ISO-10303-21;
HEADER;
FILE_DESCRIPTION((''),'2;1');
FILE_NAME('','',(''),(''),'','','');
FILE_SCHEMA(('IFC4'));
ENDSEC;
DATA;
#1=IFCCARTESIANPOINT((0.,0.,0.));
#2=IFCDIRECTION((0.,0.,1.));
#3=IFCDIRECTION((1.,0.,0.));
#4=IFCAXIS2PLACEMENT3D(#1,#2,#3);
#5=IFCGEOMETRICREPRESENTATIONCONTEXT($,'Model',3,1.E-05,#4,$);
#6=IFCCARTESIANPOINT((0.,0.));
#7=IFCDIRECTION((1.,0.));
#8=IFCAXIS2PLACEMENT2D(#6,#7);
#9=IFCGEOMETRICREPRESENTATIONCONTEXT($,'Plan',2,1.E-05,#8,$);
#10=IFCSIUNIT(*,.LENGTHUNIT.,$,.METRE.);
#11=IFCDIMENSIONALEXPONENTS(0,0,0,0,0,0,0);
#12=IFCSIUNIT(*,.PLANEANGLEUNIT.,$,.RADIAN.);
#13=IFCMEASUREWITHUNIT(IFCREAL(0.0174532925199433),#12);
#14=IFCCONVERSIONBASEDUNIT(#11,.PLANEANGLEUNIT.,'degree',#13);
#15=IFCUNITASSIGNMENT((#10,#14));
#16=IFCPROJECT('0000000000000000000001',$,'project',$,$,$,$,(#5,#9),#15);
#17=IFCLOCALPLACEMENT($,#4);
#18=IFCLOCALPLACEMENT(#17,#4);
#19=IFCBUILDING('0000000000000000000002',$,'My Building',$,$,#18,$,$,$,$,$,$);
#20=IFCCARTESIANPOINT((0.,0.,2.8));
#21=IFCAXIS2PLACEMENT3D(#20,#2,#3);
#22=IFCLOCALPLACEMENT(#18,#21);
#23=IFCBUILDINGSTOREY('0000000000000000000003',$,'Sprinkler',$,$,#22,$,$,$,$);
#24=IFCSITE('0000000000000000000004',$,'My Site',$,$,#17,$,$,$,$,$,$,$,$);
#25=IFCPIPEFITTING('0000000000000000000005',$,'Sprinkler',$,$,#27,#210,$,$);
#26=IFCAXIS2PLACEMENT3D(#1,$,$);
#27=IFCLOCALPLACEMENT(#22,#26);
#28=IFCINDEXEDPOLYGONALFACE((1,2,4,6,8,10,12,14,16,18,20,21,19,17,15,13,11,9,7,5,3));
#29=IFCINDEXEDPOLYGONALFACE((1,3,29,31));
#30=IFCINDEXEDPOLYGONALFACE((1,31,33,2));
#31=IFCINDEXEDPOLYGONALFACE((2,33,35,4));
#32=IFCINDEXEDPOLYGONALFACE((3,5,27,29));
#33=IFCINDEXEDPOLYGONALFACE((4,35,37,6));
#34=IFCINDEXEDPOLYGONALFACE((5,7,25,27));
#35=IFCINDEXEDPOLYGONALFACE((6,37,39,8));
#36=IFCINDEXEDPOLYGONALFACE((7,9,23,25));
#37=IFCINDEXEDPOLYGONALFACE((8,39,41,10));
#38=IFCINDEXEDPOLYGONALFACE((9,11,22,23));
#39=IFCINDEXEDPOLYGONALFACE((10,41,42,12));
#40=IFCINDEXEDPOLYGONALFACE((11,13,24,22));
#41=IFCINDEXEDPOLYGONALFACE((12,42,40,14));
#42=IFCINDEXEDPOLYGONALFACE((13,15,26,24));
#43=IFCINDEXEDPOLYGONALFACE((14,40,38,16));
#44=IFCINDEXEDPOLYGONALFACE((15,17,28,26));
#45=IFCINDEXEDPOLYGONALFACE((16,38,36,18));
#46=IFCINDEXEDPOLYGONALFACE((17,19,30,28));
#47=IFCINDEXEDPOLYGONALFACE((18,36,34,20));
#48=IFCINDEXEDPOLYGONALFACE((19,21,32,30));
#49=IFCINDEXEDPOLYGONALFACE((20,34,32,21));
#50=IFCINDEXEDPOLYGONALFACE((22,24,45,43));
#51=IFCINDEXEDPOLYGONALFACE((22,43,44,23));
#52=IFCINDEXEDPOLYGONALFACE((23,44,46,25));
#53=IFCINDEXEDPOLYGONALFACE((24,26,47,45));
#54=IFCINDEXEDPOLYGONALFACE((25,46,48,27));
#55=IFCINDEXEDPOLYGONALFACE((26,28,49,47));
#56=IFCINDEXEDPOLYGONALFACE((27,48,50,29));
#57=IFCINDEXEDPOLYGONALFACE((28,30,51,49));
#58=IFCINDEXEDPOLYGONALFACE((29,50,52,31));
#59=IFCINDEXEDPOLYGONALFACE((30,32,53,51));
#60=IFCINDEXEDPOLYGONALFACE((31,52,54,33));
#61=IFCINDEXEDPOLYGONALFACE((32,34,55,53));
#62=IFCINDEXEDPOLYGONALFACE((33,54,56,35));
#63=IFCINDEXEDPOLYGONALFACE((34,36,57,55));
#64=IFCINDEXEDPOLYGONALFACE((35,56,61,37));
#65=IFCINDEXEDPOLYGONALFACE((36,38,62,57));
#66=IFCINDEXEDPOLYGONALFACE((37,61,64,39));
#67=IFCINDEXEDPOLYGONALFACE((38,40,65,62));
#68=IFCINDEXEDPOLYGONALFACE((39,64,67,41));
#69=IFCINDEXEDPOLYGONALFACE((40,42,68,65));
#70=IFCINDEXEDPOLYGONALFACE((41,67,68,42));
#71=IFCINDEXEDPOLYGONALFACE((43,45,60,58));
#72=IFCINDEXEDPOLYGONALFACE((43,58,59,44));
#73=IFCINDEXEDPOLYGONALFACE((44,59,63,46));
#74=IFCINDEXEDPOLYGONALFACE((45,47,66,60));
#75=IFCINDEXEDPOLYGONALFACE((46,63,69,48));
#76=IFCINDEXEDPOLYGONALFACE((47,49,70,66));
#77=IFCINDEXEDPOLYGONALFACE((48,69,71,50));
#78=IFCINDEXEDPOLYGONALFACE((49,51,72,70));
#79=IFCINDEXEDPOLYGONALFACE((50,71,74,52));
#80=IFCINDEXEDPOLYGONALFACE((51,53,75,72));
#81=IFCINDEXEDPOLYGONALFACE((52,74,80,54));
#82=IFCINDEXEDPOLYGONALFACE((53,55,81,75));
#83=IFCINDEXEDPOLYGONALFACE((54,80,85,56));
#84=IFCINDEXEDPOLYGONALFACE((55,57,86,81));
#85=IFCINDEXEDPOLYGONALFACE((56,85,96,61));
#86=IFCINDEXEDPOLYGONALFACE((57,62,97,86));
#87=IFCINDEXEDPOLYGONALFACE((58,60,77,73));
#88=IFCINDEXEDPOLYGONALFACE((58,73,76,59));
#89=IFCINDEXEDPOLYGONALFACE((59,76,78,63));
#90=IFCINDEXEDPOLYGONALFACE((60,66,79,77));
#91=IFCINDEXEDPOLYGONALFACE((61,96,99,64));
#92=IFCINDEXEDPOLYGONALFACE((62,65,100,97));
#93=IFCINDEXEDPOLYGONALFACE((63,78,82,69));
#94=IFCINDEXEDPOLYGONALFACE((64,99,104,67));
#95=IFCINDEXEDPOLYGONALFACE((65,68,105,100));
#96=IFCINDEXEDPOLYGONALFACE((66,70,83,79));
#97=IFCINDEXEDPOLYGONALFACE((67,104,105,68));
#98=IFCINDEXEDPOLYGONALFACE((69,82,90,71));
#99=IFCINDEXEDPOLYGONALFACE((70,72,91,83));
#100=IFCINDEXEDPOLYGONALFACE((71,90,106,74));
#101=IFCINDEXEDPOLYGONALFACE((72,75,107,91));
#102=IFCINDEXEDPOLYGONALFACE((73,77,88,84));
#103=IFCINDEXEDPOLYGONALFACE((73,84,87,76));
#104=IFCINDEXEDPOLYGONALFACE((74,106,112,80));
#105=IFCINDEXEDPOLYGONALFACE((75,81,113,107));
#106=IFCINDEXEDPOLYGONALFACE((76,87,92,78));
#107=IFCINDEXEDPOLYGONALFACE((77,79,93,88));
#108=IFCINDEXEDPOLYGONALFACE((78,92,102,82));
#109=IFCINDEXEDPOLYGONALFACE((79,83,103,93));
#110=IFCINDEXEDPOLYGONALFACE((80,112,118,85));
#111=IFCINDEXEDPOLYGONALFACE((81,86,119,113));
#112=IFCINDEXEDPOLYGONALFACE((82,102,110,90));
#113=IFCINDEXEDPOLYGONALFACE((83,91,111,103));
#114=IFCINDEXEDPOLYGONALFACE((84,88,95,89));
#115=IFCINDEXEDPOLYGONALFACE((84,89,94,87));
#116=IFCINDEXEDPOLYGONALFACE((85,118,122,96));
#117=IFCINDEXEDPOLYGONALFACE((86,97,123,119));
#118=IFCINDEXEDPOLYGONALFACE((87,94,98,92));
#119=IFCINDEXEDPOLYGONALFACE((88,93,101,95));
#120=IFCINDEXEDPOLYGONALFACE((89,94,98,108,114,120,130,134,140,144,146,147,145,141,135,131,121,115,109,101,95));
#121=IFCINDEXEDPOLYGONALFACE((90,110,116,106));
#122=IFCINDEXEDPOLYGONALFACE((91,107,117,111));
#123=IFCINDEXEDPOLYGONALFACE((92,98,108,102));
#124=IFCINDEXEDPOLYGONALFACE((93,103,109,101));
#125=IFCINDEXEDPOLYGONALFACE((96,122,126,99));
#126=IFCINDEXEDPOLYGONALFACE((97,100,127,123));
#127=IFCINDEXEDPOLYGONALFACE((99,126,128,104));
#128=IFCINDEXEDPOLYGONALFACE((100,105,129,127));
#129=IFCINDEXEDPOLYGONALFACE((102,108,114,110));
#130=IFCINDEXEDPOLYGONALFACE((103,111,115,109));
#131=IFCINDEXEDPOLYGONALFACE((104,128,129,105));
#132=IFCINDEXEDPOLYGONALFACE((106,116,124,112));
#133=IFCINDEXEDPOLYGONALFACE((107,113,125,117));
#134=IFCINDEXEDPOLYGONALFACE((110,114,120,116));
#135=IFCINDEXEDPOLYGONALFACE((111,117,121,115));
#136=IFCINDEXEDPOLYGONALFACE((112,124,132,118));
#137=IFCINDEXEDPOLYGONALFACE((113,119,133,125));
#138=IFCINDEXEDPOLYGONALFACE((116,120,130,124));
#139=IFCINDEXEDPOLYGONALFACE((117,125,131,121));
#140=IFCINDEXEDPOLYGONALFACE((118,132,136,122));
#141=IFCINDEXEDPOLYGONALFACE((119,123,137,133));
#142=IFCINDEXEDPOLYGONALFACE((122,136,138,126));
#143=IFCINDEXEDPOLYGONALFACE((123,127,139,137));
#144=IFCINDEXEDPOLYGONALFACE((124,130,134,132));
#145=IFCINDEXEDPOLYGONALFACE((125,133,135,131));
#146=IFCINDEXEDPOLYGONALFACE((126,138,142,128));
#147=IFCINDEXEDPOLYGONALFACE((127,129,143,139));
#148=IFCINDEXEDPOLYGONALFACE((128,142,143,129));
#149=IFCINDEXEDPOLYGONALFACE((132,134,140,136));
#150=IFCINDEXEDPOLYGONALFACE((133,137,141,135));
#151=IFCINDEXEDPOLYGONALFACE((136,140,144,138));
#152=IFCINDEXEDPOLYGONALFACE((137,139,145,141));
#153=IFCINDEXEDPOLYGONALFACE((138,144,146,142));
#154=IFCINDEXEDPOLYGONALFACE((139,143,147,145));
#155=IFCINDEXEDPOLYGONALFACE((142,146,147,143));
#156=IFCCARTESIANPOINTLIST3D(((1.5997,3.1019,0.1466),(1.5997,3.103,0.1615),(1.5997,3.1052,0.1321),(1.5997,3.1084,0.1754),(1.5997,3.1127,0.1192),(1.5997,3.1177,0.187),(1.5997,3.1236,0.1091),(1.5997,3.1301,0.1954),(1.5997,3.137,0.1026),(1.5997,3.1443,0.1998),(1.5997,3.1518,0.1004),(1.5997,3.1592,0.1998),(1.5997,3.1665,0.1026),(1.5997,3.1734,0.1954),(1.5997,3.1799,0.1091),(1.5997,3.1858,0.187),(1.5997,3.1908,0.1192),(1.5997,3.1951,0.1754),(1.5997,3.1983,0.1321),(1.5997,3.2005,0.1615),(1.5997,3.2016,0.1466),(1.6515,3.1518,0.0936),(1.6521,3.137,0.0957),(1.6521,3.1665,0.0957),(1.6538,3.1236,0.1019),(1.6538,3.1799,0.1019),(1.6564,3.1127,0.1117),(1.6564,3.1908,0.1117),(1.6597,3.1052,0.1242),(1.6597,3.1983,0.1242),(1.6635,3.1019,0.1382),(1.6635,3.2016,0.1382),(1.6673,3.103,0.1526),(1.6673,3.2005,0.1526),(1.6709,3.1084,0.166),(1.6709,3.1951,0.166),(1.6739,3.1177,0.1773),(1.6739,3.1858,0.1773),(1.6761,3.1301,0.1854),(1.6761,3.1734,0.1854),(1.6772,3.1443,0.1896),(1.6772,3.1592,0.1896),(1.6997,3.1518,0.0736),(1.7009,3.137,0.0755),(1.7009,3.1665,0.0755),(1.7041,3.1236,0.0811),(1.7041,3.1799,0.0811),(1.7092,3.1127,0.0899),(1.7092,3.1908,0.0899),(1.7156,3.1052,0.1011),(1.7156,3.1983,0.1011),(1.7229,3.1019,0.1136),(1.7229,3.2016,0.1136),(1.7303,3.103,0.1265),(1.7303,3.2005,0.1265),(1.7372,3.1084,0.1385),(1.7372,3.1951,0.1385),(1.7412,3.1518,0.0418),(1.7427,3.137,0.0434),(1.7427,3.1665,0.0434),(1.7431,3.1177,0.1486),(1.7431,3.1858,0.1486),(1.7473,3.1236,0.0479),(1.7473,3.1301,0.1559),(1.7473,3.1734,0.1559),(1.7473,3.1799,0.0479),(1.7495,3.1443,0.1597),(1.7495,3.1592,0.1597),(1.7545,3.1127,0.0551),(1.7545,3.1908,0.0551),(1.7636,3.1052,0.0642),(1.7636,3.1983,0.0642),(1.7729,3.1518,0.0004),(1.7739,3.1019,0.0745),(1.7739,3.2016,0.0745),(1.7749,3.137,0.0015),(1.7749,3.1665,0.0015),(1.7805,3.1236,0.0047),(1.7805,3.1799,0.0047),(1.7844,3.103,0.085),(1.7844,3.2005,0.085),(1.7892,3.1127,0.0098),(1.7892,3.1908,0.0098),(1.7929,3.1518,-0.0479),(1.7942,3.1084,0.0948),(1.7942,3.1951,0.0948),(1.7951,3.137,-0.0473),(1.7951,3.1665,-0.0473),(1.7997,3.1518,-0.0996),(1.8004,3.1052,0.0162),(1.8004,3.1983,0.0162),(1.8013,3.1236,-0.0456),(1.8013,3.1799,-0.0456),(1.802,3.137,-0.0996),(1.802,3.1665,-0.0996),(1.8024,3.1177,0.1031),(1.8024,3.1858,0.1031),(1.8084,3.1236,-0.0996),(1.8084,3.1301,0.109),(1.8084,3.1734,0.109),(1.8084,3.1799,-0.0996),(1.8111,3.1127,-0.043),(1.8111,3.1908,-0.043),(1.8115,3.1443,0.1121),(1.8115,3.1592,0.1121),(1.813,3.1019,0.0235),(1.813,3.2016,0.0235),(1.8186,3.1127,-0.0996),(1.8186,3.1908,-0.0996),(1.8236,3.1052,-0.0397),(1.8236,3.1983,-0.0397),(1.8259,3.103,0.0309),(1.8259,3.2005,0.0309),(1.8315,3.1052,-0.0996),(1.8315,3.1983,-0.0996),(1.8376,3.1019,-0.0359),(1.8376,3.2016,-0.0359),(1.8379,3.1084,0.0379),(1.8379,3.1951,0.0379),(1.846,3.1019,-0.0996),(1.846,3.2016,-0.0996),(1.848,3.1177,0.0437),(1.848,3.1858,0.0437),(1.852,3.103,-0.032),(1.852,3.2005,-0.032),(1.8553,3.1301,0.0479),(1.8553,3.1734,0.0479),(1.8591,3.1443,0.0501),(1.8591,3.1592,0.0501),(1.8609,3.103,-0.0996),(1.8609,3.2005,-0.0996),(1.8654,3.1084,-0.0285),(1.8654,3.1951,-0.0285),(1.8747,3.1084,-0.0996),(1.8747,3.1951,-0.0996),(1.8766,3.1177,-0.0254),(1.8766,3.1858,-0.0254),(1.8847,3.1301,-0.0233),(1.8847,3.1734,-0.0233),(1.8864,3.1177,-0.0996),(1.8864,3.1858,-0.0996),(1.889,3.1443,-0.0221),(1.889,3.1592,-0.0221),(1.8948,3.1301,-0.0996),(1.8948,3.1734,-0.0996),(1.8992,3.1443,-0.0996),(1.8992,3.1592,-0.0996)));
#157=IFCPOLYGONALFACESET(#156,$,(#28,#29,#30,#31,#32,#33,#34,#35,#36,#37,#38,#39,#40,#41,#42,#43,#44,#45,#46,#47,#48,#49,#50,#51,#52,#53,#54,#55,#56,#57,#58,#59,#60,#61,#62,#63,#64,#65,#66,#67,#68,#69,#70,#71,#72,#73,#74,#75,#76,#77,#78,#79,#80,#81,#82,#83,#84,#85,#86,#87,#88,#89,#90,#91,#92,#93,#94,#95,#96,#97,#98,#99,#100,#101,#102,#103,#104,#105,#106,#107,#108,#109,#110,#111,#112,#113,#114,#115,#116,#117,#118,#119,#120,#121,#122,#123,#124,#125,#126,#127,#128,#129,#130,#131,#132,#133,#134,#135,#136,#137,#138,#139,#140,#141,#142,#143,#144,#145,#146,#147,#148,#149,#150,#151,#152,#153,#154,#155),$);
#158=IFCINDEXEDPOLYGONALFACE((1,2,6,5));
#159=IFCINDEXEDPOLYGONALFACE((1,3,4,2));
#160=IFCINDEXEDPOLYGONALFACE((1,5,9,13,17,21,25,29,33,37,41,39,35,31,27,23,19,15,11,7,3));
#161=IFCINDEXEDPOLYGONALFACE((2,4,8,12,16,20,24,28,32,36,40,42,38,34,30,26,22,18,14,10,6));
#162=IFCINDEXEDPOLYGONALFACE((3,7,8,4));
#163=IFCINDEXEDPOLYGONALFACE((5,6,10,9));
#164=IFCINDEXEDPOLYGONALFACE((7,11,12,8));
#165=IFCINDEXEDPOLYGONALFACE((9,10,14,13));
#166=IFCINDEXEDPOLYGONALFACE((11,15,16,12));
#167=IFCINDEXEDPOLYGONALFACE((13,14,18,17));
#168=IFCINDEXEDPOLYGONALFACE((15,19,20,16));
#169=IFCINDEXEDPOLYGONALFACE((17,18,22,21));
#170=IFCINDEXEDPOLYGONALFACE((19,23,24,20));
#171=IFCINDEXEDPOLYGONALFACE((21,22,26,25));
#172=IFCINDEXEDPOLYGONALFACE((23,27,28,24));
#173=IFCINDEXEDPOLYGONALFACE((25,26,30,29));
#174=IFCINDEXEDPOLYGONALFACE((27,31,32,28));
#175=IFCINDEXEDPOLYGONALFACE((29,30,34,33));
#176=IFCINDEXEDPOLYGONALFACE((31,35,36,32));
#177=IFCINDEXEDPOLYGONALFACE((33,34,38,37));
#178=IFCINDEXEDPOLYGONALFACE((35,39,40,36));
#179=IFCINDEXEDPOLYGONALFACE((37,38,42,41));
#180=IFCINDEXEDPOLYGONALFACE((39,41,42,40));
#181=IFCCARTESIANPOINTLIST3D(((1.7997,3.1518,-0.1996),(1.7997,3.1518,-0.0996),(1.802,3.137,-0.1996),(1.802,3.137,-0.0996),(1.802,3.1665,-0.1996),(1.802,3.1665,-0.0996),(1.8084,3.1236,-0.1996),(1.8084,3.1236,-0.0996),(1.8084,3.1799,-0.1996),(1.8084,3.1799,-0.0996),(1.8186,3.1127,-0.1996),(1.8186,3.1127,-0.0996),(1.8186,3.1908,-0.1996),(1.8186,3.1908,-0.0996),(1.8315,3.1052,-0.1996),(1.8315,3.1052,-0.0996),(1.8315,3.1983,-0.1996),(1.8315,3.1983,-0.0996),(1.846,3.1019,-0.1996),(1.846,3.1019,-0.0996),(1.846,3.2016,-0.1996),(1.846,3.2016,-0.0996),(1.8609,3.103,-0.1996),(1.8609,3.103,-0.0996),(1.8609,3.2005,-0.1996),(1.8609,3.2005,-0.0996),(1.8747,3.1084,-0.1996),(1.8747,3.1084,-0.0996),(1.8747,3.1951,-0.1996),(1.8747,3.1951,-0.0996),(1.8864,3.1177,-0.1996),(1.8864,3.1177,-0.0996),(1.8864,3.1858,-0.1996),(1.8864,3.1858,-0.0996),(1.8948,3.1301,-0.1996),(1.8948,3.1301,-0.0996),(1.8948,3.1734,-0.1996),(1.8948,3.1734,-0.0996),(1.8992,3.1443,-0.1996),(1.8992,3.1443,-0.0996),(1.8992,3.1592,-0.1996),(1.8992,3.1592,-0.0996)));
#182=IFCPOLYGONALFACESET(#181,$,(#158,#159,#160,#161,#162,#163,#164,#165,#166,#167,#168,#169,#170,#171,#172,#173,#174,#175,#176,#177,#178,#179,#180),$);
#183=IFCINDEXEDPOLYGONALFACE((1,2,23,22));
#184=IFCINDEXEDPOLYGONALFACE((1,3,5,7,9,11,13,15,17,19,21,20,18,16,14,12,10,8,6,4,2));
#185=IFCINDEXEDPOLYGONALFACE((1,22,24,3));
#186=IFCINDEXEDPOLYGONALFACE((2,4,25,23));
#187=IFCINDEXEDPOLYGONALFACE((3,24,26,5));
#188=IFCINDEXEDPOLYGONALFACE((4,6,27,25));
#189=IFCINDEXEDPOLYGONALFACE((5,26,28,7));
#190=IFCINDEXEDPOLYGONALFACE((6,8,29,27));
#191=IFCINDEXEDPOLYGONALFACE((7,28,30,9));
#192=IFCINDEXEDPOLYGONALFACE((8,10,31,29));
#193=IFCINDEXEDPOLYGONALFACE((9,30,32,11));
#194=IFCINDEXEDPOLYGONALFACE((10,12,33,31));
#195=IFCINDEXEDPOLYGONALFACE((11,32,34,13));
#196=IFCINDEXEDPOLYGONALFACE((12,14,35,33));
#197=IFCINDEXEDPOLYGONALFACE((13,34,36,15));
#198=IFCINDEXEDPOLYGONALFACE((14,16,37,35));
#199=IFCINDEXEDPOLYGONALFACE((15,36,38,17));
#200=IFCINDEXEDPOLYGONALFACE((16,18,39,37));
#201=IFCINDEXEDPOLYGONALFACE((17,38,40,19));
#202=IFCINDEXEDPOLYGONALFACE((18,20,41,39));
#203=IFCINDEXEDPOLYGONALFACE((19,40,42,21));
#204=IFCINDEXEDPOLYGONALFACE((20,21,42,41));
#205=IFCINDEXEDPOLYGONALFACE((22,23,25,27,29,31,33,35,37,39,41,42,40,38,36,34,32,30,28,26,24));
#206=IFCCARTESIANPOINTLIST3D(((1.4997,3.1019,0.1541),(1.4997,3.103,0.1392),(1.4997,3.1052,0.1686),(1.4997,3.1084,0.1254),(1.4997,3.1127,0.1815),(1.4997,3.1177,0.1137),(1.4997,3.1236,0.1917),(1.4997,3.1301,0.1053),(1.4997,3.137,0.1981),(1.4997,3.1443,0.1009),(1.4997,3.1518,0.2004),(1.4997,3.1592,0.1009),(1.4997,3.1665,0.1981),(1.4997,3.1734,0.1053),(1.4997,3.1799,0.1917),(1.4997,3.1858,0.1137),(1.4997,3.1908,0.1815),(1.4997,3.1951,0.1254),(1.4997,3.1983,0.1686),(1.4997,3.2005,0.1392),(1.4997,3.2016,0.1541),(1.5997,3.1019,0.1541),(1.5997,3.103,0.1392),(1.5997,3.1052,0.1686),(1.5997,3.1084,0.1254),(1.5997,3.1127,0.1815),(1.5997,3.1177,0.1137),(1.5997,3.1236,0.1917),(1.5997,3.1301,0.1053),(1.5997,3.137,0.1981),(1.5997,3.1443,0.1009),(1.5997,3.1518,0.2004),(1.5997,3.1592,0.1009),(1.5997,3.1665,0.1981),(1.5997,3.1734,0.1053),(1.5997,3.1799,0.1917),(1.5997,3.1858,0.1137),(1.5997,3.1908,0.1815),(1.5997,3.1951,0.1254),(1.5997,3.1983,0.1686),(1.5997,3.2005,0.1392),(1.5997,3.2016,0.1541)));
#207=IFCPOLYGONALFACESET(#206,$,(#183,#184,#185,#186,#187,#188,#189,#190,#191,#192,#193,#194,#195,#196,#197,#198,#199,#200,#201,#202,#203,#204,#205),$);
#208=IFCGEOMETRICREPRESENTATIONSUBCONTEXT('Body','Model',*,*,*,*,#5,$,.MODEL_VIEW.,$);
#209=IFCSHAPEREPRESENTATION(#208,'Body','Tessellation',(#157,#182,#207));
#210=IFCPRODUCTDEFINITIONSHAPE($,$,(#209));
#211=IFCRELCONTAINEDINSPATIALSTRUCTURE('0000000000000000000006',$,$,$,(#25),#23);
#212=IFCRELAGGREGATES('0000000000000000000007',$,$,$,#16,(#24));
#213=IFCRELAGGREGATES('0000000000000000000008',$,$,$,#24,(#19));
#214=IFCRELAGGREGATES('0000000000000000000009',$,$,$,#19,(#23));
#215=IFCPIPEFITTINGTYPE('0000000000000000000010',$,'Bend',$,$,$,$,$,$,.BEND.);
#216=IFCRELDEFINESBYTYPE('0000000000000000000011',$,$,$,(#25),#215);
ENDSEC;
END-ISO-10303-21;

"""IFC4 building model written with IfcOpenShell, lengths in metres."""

from ifc_helpers import new_model, entity, si_unit, converted_unit, frame, origin_with_axes, origin_2d_with_axis, place, context, subcontext, project, spatial, circle, extrude, source, transform, mapped, type_object, type_shapes, element, save


model = new_model("IFC4")

# Units and contexts
model_context = context("Model", 3, precision=1e-05, world=origin_with_axes())
plan_context = context("Plan", 2, precision=1e-05, world=origin_2d_with_axis())
body_context = subcontext(model_context, "Body", "Model", "MODEL_VIEW")
ifc_project = project(units=[si_unit("LENGTHUNIT", "METRE"), converted_unit("PLANEANGLEUNIT", "degree", entity("IfcReal", 0.0174532925199433), si_unit("PLANEANGLEUNIT", "RADIAN"), dimensions=[0, 0, 0, 0, 0, 0, 0])], contexts=[model_context, plan_context])

# Site, building, storey
site_placement = place(None, origin_with_axes())
site = spatial("IfcSite", under=ifc_project, at=site_placement, Name="My Site")
building_placement = place(site_placement, origin_with_axes())
building = spatial("IfcBuilding", under=site, at=building_placement, Name="My Building")
storey_placement = place(building_placement, frame((0.0, 0.0, 2.8), z_axis=(0.0, 0.0, 1.0), x_axis=(1.0, 0.0, 0.0)))
storey = spatial("IfcBuildingStorey", under=building, at=storey_placement, Name="Sprinkler")

# Pipe fitting
pipe_fitting_type_1 = type_object("IfcPipeFittingType", Name="Bend", PredefinedType="BEND")
shared_shape = source(origin_with_axes(), body_context, "Body", "SolidModel", [
    entity("IfcSweptDiskSolid", entity("IfcIndexedPolyCurve", entity("IfcCartesianPointList3D", [[0.0, 0.0, 0.1], [0.0732, 0.0, 0.2768], [0.25, 0.0, 0.35]]), [entity("IfcArcIndex", [1, 2, 3])]), 0.05),
    extrude(circle(Radius=0.05), origin_with_axes(), (0.0, 0.0, 1.0), 0.1),
    extrude(circle(Radius=0.05), frame((0.25, 0.0, 0.35), z_axis=(1.0, 0.0, 0.000001), x_axis=(-0.000001, 0.0, 1.0)), (0.0, 0.0, 1.0), 0.1),
])
type_shapes(pipe_fitting_type_1, [shared_shape])
for number, where, z_axis, x_axis, name in (
    (1, (1.8497, 3.1518, -0.1996), (-0.000008, 0.0, 1.0), (-1.0, 0.0, -0.000008), "Sprinkler"),
):
    element("IfcPipeFitting", number, at=place(storey_placement, frame(where, z_axis=z_axis, x_axis=x_axis)), inside=storey, type_object=pipe_fitting_type_1, Name=name, context=body_context, shape_type="MappedRepresentation", body=[
        mapped(shared_shape, transform((0.0, 0.0, 0.0), x_axis=(1.0, 0.0, 0.0), y_axis=(0.0, 1.0, 0.0), z_axis=(0.0, 0.0, 1.0), scale=1.0)),
    ])

save(model, "model.ifc")
